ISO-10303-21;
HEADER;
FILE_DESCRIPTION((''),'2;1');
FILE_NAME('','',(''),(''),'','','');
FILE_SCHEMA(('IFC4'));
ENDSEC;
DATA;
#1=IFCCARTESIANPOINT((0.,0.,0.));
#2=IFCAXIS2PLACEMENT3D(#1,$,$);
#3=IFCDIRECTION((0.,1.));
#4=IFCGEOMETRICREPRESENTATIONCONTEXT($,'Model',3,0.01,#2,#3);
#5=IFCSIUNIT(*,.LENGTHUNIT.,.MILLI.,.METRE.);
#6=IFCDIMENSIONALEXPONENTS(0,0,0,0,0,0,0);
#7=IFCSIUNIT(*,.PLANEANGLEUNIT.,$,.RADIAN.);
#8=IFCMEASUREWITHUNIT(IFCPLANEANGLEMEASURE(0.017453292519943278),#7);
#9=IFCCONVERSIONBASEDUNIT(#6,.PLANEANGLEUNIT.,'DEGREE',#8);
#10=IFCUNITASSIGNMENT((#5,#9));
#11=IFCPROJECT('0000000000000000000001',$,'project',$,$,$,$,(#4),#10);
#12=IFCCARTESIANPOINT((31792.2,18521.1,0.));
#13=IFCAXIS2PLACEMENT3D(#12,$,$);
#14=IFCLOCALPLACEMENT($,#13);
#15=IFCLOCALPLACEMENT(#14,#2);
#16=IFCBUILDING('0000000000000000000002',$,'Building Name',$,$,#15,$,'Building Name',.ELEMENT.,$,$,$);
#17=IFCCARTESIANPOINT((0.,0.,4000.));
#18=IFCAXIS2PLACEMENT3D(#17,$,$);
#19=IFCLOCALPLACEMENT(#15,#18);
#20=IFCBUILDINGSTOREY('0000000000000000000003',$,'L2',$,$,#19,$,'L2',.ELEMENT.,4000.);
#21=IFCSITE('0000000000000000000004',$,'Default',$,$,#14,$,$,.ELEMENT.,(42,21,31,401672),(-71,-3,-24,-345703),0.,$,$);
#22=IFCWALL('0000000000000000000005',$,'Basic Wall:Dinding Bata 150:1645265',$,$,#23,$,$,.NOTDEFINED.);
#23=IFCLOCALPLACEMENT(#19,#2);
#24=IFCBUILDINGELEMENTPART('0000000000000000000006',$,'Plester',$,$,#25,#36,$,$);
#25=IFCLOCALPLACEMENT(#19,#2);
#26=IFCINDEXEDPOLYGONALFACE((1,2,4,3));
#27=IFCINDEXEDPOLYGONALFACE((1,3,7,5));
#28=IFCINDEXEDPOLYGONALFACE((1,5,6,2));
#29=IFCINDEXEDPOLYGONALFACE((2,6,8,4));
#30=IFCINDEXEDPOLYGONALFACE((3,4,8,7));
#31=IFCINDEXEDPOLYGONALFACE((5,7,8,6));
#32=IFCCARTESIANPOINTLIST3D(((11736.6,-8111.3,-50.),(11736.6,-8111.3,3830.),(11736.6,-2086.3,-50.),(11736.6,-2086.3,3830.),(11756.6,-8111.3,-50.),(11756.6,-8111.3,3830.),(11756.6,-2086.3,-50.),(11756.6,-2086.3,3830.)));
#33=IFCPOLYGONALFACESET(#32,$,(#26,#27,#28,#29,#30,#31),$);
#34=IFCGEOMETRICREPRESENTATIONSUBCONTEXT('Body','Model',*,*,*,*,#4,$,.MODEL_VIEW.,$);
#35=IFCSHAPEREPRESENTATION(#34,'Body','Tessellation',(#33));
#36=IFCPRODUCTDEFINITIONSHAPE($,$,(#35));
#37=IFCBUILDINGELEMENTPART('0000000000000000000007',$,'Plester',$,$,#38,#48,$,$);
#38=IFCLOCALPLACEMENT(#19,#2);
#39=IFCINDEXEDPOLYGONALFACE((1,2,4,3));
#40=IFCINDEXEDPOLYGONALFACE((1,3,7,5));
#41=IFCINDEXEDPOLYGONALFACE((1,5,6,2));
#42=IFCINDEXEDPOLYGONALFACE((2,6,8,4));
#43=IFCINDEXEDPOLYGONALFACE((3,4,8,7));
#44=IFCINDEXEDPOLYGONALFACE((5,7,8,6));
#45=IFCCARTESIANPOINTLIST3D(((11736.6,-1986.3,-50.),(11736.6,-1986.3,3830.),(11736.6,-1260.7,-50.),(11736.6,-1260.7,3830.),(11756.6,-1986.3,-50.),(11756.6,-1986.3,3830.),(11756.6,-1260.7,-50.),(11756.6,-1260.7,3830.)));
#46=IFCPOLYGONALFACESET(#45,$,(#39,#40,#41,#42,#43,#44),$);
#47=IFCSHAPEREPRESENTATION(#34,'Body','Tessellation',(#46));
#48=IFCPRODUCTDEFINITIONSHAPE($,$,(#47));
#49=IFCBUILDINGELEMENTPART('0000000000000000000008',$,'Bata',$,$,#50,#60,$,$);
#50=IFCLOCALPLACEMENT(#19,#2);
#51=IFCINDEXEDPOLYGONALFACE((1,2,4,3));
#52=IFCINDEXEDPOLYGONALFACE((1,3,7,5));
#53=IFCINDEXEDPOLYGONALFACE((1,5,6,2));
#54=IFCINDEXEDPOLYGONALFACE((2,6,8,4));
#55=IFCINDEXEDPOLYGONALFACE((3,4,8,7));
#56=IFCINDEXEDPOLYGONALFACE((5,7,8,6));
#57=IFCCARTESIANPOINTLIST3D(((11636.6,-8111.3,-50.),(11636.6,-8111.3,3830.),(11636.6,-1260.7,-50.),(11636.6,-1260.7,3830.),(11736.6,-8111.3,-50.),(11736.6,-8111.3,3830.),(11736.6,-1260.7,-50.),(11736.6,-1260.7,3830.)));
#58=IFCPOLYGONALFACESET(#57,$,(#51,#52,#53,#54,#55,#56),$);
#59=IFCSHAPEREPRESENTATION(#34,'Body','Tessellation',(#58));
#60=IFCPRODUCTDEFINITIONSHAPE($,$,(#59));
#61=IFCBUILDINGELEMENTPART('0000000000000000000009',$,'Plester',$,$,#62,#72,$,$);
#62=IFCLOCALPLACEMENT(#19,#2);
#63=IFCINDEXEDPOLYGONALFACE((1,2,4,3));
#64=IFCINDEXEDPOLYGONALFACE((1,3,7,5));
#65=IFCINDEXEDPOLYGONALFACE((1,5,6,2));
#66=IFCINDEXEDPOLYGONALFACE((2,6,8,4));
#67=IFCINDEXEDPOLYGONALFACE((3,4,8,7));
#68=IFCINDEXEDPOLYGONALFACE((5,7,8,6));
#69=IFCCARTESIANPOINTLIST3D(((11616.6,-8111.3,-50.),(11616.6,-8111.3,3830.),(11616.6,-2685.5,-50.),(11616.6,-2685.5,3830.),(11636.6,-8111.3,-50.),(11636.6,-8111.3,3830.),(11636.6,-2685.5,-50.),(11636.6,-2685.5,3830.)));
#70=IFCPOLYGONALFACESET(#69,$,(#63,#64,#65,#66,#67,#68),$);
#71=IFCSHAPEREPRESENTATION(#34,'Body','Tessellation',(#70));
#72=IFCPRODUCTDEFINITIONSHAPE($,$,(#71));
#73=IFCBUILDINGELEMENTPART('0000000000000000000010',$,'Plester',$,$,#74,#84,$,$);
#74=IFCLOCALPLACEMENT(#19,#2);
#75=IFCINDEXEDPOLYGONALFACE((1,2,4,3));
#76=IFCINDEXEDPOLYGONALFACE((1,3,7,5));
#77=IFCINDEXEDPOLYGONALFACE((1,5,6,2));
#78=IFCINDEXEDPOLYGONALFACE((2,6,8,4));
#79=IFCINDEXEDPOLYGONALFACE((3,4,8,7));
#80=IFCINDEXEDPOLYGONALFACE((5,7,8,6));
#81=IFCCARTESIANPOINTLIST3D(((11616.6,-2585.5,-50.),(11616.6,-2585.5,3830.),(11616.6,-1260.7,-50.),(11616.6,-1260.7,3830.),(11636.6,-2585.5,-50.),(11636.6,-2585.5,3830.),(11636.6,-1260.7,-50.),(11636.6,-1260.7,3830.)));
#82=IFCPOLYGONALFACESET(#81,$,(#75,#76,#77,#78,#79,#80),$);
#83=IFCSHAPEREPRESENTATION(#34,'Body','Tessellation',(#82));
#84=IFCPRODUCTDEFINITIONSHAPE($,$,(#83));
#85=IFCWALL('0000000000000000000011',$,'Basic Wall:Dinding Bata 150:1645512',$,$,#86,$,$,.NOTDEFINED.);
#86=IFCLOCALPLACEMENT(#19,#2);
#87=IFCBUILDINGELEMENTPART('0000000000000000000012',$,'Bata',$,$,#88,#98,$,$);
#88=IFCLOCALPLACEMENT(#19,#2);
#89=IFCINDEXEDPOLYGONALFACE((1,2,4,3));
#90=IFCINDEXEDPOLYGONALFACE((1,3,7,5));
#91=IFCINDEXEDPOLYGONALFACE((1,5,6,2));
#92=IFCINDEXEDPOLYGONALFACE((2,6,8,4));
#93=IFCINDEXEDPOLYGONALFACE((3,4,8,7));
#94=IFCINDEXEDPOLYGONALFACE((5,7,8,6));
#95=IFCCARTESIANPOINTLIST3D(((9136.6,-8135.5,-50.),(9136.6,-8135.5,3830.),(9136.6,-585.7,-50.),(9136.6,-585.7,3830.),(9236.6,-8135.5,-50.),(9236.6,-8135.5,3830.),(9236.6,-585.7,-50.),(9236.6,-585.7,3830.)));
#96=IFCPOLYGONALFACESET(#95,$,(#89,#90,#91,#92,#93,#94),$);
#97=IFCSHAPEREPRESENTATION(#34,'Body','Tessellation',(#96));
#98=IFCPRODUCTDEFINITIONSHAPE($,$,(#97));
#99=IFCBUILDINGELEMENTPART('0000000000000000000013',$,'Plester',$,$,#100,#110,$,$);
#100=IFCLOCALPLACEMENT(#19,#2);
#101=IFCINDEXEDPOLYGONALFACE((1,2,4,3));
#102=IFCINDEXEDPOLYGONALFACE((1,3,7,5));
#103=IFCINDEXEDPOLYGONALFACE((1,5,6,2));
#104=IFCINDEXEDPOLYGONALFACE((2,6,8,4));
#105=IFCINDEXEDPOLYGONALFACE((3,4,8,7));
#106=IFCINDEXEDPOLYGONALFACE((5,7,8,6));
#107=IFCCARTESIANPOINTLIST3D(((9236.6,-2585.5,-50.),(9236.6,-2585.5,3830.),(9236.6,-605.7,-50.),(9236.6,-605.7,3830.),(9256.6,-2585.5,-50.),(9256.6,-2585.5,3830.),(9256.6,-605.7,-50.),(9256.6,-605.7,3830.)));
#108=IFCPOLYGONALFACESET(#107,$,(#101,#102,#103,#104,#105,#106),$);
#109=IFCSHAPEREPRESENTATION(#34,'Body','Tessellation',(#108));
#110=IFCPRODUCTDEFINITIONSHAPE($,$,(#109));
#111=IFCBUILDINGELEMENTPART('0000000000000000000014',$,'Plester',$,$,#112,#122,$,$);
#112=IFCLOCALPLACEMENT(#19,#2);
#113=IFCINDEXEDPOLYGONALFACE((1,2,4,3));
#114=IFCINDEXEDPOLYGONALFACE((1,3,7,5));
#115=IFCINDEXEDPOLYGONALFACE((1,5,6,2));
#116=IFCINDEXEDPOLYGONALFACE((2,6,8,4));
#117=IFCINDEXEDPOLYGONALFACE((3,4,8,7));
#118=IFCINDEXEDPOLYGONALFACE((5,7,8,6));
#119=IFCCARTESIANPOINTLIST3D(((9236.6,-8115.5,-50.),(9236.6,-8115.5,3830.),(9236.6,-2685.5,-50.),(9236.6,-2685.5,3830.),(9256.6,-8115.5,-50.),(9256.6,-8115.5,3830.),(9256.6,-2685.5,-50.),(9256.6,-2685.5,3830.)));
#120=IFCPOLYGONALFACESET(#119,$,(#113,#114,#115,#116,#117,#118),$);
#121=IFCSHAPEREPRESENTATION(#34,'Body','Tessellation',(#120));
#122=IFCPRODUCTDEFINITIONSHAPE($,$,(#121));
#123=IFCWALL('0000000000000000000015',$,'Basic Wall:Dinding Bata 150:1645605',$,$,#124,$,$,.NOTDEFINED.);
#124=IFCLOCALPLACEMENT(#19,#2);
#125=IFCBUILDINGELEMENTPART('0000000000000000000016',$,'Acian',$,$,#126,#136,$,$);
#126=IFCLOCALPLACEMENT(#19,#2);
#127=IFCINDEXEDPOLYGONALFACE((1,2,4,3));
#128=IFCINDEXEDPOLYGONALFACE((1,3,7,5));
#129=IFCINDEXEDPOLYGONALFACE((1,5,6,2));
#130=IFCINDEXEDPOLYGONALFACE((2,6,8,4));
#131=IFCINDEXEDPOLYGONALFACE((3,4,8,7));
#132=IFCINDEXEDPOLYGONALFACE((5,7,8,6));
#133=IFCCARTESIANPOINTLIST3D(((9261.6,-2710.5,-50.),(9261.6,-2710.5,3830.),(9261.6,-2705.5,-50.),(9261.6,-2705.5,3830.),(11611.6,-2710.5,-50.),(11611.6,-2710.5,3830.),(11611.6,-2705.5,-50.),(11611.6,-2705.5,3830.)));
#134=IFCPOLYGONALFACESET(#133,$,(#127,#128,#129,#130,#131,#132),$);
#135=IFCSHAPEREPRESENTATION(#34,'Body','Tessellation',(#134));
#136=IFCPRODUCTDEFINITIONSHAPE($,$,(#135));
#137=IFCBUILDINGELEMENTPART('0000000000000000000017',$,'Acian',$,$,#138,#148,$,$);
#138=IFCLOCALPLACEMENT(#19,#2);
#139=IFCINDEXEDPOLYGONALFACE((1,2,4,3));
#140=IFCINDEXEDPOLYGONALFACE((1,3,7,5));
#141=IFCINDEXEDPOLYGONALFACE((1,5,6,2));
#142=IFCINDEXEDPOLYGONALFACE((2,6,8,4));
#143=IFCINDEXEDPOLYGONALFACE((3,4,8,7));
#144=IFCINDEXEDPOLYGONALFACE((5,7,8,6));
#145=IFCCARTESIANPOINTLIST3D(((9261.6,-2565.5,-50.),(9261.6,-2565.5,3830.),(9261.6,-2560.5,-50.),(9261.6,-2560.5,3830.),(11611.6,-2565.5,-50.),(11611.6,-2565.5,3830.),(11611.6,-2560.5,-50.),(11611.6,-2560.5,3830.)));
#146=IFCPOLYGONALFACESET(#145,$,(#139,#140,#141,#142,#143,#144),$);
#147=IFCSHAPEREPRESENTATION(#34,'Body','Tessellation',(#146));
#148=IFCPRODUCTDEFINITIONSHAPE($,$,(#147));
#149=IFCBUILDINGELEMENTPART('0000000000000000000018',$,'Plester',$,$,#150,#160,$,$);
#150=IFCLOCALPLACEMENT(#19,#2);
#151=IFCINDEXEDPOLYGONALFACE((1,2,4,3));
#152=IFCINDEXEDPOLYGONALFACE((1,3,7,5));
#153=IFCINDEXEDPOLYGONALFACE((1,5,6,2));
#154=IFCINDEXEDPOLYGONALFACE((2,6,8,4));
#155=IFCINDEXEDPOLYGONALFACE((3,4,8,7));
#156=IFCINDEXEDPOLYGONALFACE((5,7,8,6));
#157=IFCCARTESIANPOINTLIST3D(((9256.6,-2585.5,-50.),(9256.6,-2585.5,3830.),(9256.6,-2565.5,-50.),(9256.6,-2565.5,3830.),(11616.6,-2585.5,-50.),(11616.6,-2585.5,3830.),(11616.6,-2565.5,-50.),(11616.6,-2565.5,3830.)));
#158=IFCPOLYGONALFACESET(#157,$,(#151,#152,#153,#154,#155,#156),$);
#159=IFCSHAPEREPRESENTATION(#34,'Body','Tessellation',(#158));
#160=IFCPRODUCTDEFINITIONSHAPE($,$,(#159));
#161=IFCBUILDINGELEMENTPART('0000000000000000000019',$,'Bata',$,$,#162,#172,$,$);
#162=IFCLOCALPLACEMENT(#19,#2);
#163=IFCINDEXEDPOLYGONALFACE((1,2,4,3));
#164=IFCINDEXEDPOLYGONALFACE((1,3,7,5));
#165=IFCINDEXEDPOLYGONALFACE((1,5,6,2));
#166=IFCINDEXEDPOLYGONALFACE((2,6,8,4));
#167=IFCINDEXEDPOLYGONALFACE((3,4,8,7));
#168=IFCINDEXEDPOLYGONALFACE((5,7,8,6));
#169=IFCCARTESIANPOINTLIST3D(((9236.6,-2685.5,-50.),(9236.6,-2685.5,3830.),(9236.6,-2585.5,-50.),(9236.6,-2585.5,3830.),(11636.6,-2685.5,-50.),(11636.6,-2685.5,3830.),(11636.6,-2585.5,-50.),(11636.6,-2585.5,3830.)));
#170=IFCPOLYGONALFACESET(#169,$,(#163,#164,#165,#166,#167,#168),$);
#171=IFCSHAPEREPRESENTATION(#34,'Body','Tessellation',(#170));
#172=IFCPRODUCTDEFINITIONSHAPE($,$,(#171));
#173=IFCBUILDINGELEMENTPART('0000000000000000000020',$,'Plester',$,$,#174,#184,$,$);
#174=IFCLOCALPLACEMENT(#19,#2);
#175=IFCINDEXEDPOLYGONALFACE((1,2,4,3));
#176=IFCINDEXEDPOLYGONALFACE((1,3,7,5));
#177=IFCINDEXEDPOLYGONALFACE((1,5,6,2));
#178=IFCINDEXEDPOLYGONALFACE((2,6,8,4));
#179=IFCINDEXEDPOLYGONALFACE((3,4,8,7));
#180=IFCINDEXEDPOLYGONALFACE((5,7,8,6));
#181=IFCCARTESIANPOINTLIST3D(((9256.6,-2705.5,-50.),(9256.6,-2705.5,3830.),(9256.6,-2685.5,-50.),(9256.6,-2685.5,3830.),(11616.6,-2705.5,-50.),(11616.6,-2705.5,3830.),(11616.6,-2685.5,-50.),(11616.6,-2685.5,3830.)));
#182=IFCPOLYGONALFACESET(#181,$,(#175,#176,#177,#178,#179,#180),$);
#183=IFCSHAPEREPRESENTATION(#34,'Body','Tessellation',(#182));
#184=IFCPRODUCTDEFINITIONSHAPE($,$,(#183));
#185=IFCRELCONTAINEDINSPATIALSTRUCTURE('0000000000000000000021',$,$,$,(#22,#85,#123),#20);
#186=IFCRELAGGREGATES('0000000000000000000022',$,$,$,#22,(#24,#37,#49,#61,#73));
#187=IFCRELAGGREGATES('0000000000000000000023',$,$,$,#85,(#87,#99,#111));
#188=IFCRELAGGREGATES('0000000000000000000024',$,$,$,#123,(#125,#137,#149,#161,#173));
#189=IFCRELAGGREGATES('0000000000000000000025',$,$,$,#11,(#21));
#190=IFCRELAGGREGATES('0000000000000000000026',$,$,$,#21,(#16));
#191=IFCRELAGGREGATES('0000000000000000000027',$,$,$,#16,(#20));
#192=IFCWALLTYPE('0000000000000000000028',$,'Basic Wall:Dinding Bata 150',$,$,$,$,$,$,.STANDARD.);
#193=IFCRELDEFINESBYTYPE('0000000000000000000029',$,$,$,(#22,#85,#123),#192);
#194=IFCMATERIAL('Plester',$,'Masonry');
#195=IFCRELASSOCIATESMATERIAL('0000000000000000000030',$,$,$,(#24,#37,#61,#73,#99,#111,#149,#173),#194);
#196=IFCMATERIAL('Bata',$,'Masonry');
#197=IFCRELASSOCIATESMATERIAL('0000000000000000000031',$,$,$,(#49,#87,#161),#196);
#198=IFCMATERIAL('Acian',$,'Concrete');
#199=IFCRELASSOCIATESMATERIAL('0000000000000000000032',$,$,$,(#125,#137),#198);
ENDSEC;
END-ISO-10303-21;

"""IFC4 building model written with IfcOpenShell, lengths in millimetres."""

from ifc_helpers import new_model, entity, si_unit, converted_unit, direction, frame, origin, place, context, subcontext, project, spatial, indexed_curve, outline, extrude, material, type_object, element, aggregate, save


model = new_model("IFC4")

# Units and contexts
model_context = context("Model", 3, precision=0.01, world=origin(), true_north=direction((0.0, 1.0)))
body_context = subcontext(model_context, "Body", "Model", "MODEL_VIEW")
ifc_project = project(units=[si_unit("LENGTHUNIT", "METRE", prefix="MILLI"), converted_unit("PLANEANGLEUNIT", "DEGREE", entity("IfcPlaneAngleMeasure", 0.017453292519943278), si_unit("PLANEANGLEUNIT", "RADIAN"), dimensions=[0, 0, 0, 0, 0, 0, 0])], contexts=[model_context])

# Site, building, storey
site_placement = place(None, frame((31792.2, 18521.1, 0.0)))
site = spatial("IfcSite", under=ifc_project, at=site_placement, Name="Default", CompositionType="ELEMENT", RefLatitude=(42, 21, 31, 401672), RefLongitude=(-71, -3, -24, -345703), RefElevation=0.0)
building_placement = place(site_placement, origin())
building = spatial("IfcBuilding", under=site, at=building_placement, Name="Building Name", LongName="Building Name", CompositionType="ELEMENT")
storey_placement = place(building_placement, frame((0.0, 0.0, 4000.0)))
storey = spatial("IfcBuildingStorey", under=building, at=storey_placement, Name="L2", LongName="L2", CompositionType="ELEMENT", Elevation=4000.0)

# Walls, building element parts
wall_type = type_object("IfcWallType", Name="Basic Wall:Dinding Bata 150", PredefinedType="STANDARD")
ifc_material_1 = material(Name="Acian", Category="Concrete")
ifc_material_2 = material(Name="Plester", Category="Masonry")
ifc_material_3 = material(Name="Bata", Category="Masonry")
wall_1_placement = place(storey_placement, frame((11686.6, -1260.7, -50.0), z_axis=(0.0, 0.0, 1.0), x_axis=(0.0, -1.0, 0.0)))
wall_1 = element("IfcWall", 1, at=wall_1_placement, inside=storey, type_object=wall_type, Name="Basic Wall:Dinding Bata 150:1645265", PredefinedType="NOTDEFINED")
building_element_part_1_placement = place(wall_1_placement, origin())
building_element_part_1 = element("IfcBuildingElementPart", 2, at=building_element_part_1_placement, material=ifc_material_2, Name="Plester", context=body_context, shape_type="SweptSolid", body=[
    extrude(outline(indexed_curve([(-3012.5, -10.0), (3012.5, -10.0), (3012.5, 10.0), (-3012.5, 10.0), (-3012.5, -10.0)], self_intersect=False)), frame((3838.1, 60.0, 0.0)), (0.0, 0.0, 1.0), 3880.0),
])
building_element_part_2_placement = place(wall_1_placement, origin())
building_element_part_2 = element("IfcBuildingElementPart", 3, at=building_element_part_2_placement, material=ifc_material_2, Name="Plester", context=body_context, shape_type="SweptSolid", body=[
    extrude(outline(indexed_curve([(-362.8, -10.0), (362.8, -10.0), (362.8, 10.0), (-362.8, 10.0), (-362.8, -10.0)], self_intersect=False)), frame((362.8, 60.0, 0.0)), (0.0, 0.0, 1.0), 3880.0),
])
building_element_part_3_placement = place(wall_1_placement, origin())
building_element_part_3 = element("IfcBuildingElementPart", 4, at=building_element_part_3_placement, material=ifc_material_3, Name="Bata", context=body_context, shape_type="SweptSolid", body=[
    extrude(outline(indexed_curve([(-3425.3, -50.0), (3425.3, -50.0), (3425.3, 50.0), (-3425.3, 50.0), (-3425.3, -50.0)], self_intersect=False)), frame((3425.3, 0.0, 0.0)), (0.0, 0.0, 1.0), 3880.0),
])
building_element_part_4_placement = place(wall_1_placement, origin())
building_element_part_4 = element("IfcBuildingElementPart", 5, at=building_element_part_4_placement, material=ifc_material_2, Name="Plester", context=body_context, shape_type="SweptSolid", body=[
    extrude(outline(indexed_curve([(-2712.9, -10.0), (2712.9, -10.0), (2712.9, 10.0), (-2712.9, 10.0), (-2712.9, -10.0)], self_intersect=False)), frame((4137.6, -60.0, 0.0)), (0.0, 0.0, 1.0), 3880.0),
])
building_element_part_5_placement = place(wall_1_placement, origin())
building_element_part_5 = element("IfcBuildingElementPart", 6, at=building_element_part_5_placement, material=ifc_material_2, Name="Plester", context=body_context, shape_type="SweptSolid", body=[
    extrude(outline(indexed_curve([(-662.4, -10.0), (662.4, -10.0), (662.4, 10.0), (-662.4, 10.0), (-662.4, -10.0)], self_intersect=False)), frame((662.4, -60.0, 0.0)), (0.0, 0.0, 1.0), 3880.0),
])
aggregate(wall_1, [building_element_part_1, building_element_part_2, building_element_part_3, building_element_part_4, building_element_part_5])
wall_2_placement = place(storey_placement, frame((9186.6, -8110.5, -50.0), z_axis=(0.0, 0.0, 1.0), x_axis=(0.0, 1.0, 0.0)))
wall_2 = element("IfcWall", 7, at=wall_2_placement, inside=storey, type_object=wall_type, Name="Basic Wall:Dinding Bata 150:1645512", PredefinedType="NOTDEFINED")
building_element_part_6_placement = place(wall_2_placement, origin())
building_element_part_6 = element("IfcBuildingElementPart", 8, at=building_element_part_6_placement, material=ifc_material_3, Name="Bata", context=body_context, shape_type="SweptSolid", body=[
    extrude(outline(indexed_curve([(-3774.9, -50.0), (3774.9, -50.0), (3774.9, 50.0), (-3774.9, 50.0), (-3774.9, -50.0)], self_intersect=False)), frame((3749.9, 0.0, 0.0), z_axis=(0.0, 0.0, 1.0), x_axis=(-1.0, 0.0, 0.0)), (0.0, 0.0, 1.0), 3880.0),
])
building_element_part_7_placement = place(wall_2_placement, origin())
building_element_part_7 = element("IfcBuildingElementPart", 9, at=building_element_part_7_placement, material=ifc_material_2, Name="Plester", context=body_context, shape_type="SweptSolid", body=[
    extrude(outline(indexed_curve([(-989.9, -10.0), (989.9, -10.0), (989.9, 10.0), (-989.9, 10.0), (-989.9, -10.0)], self_intersect=False)), frame((6514.9, -60.0, 0.0), z_axis=(0.0, 0.0, 1.0), x_axis=(-1.0, 0.0, 0.0)), (0.0, 0.0, 1.0), 3880.0),
])
building_element_part_8_placement = place(wall_2_placement, origin())
building_element_part_8 = element("IfcBuildingElementPart", 10, at=building_element_part_8_placement, material=ifc_material_2, Name="Plester", context=body_context, shape_type="SweptSolid", body=[
    extrude(outline(indexed_curve([(-2715.0, -10.0), (2715.0, -10.0), (2715.0, 10.0), (-2715.0, 10.0), (-2715.0, -10.0)], self_intersect=False)), frame((2710.0, -60.0, 0.0), z_axis=(0.0, 0.0, 1.0), x_axis=(-1.0, 0.0, 0.0)), (0.0, 0.0, 1.0), 3880.0),
])
aggregate(wall_2, [building_element_part_6, building_element_part_7, building_element_part_8])
wall_3_placement = place(storey_placement, frame((9261.6, -2635.5, -50.0)))
wall_3 = element("IfcWall", 11, at=wall_3_placement, inside=storey, type_object=wall_type, Name="Basic Wall:Dinding Bata 150:1645605", PredefinedType="NOTDEFINED")
building_element_part_9_placement = place(wall_3_placement, origin())
building_element_part_9 = element("IfcBuildingElementPart", 12, at=building_element_part_9_placement, material=ifc_material_1, Name="Acian", context=body_context, shape_type="SweptSolid", body=[
    extrude(outline(indexed_curve([(-2.5, -1175.0), (2.5, -1175.0), (2.5, 1175.0), (-2.5, 1175.0), (-2.5, -1175.0)], self_intersect=False)), frame((1175.0, -72.5, 0.0), z_axis=(0.0, 0.0, 1.0), x_axis=(0.0, -1.0, 0.0)), (0.0, 0.0, 1.0), 3880.0),
])
building_element_part_10_placement = place(wall_3_placement, origin())
building_element_part_10 = element("IfcBuildingElementPart", 13, at=building_element_part_10_placement, material=ifc_material_1, Name="Acian", context=body_context, shape_type="SweptSolid", body=[
    extrude(outline(indexed_curve([(-2.5, -1175.0), (2.5, -1175.0), (2.5, 1175.0), (-2.5, 1175.0), (-2.5, -1175.0)], self_intersect=False)), frame((1175.0, 72.5, 0.0), z_axis=(0.0, 0.0, 1.0), x_axis=(0.0, -1.0, 0.0)), (0.0, 0.0, 1.0), 3880.0),
])
building_element_part_11_placement = place(wall_3_placement, origin())
building_element_part_11 = element("IfcBuildingElementPart", 14, at=building_element_part_11_placement, material=ifc_material_2, Name="Plester", context=body_context, shape_type="SweptSolid", body=[
    extrude(outline(indexed_curve([(-10.0, -1180.0), (10.0, -1180.0), (10.0, 1180.0), (-10.0, 1180.0), (-10.0, -1180.0)], self_intersect=False)), frame((1175.0, 60.0, 0.0), z_axis=(0.0, 0.0, 1.0), x_axis=(0.0, -1.0, 0.0)), (0.0, 0.0, 1.0), 3880.0),
])
building_element_part_12_placement = place(wall_3_placement, origin())
building_element_part_12 = element("IfcBuildingElementPart", 15, at=building_element_part_12_placement, material=ifc_material_3, Name="Bata", context=body_context, shape_type="SweptSolid", body=[
    extrude(outline(indexed_curve([(-50.0, -1200.0), (50.0, -1200.0), (50.0, 1200.0), (-50.0, 1200.0), (-50.0, -1200.0)], self_intersect=False)), frame((1175.0, 0.0, 0.0), z_axis=(0.0, 0.0, 1.0), x_axis=(0.0, -1.0, 0.0)), (0.0, 0.0, 1.0), 3880.0),
])
building_element_part_13_placement = place(wall_3_placement, origin())
building_element_part_13 = element("IfcBuildingElementPart", 16, at=building_element_part_13_placement, material=ifc_material_2, Name="Plester", context=body_context, shape_type="SweptSolid", body=[
    extrude(outline(indexed_curve([(-10.0, -1180.0), (10.0, -1180.0), (10.0, 1180.0), (-10.0, 1180.0), (-10.0, -1180.0)], self_intersect=False)), frame((1175.0, -60.0, 0.0), z_axis=(0.0, 0.0, 1.0), x_axis=(0.0, -1.0, 0.0)), (0.0, 0.0, 1.0), 3880.0),
])
aggregate(wall_3, [building_element_part_9, building_element_part_10, building_element_part_11, building_element_part_12, building_element_part_13])

save(model, "model.ifc")
